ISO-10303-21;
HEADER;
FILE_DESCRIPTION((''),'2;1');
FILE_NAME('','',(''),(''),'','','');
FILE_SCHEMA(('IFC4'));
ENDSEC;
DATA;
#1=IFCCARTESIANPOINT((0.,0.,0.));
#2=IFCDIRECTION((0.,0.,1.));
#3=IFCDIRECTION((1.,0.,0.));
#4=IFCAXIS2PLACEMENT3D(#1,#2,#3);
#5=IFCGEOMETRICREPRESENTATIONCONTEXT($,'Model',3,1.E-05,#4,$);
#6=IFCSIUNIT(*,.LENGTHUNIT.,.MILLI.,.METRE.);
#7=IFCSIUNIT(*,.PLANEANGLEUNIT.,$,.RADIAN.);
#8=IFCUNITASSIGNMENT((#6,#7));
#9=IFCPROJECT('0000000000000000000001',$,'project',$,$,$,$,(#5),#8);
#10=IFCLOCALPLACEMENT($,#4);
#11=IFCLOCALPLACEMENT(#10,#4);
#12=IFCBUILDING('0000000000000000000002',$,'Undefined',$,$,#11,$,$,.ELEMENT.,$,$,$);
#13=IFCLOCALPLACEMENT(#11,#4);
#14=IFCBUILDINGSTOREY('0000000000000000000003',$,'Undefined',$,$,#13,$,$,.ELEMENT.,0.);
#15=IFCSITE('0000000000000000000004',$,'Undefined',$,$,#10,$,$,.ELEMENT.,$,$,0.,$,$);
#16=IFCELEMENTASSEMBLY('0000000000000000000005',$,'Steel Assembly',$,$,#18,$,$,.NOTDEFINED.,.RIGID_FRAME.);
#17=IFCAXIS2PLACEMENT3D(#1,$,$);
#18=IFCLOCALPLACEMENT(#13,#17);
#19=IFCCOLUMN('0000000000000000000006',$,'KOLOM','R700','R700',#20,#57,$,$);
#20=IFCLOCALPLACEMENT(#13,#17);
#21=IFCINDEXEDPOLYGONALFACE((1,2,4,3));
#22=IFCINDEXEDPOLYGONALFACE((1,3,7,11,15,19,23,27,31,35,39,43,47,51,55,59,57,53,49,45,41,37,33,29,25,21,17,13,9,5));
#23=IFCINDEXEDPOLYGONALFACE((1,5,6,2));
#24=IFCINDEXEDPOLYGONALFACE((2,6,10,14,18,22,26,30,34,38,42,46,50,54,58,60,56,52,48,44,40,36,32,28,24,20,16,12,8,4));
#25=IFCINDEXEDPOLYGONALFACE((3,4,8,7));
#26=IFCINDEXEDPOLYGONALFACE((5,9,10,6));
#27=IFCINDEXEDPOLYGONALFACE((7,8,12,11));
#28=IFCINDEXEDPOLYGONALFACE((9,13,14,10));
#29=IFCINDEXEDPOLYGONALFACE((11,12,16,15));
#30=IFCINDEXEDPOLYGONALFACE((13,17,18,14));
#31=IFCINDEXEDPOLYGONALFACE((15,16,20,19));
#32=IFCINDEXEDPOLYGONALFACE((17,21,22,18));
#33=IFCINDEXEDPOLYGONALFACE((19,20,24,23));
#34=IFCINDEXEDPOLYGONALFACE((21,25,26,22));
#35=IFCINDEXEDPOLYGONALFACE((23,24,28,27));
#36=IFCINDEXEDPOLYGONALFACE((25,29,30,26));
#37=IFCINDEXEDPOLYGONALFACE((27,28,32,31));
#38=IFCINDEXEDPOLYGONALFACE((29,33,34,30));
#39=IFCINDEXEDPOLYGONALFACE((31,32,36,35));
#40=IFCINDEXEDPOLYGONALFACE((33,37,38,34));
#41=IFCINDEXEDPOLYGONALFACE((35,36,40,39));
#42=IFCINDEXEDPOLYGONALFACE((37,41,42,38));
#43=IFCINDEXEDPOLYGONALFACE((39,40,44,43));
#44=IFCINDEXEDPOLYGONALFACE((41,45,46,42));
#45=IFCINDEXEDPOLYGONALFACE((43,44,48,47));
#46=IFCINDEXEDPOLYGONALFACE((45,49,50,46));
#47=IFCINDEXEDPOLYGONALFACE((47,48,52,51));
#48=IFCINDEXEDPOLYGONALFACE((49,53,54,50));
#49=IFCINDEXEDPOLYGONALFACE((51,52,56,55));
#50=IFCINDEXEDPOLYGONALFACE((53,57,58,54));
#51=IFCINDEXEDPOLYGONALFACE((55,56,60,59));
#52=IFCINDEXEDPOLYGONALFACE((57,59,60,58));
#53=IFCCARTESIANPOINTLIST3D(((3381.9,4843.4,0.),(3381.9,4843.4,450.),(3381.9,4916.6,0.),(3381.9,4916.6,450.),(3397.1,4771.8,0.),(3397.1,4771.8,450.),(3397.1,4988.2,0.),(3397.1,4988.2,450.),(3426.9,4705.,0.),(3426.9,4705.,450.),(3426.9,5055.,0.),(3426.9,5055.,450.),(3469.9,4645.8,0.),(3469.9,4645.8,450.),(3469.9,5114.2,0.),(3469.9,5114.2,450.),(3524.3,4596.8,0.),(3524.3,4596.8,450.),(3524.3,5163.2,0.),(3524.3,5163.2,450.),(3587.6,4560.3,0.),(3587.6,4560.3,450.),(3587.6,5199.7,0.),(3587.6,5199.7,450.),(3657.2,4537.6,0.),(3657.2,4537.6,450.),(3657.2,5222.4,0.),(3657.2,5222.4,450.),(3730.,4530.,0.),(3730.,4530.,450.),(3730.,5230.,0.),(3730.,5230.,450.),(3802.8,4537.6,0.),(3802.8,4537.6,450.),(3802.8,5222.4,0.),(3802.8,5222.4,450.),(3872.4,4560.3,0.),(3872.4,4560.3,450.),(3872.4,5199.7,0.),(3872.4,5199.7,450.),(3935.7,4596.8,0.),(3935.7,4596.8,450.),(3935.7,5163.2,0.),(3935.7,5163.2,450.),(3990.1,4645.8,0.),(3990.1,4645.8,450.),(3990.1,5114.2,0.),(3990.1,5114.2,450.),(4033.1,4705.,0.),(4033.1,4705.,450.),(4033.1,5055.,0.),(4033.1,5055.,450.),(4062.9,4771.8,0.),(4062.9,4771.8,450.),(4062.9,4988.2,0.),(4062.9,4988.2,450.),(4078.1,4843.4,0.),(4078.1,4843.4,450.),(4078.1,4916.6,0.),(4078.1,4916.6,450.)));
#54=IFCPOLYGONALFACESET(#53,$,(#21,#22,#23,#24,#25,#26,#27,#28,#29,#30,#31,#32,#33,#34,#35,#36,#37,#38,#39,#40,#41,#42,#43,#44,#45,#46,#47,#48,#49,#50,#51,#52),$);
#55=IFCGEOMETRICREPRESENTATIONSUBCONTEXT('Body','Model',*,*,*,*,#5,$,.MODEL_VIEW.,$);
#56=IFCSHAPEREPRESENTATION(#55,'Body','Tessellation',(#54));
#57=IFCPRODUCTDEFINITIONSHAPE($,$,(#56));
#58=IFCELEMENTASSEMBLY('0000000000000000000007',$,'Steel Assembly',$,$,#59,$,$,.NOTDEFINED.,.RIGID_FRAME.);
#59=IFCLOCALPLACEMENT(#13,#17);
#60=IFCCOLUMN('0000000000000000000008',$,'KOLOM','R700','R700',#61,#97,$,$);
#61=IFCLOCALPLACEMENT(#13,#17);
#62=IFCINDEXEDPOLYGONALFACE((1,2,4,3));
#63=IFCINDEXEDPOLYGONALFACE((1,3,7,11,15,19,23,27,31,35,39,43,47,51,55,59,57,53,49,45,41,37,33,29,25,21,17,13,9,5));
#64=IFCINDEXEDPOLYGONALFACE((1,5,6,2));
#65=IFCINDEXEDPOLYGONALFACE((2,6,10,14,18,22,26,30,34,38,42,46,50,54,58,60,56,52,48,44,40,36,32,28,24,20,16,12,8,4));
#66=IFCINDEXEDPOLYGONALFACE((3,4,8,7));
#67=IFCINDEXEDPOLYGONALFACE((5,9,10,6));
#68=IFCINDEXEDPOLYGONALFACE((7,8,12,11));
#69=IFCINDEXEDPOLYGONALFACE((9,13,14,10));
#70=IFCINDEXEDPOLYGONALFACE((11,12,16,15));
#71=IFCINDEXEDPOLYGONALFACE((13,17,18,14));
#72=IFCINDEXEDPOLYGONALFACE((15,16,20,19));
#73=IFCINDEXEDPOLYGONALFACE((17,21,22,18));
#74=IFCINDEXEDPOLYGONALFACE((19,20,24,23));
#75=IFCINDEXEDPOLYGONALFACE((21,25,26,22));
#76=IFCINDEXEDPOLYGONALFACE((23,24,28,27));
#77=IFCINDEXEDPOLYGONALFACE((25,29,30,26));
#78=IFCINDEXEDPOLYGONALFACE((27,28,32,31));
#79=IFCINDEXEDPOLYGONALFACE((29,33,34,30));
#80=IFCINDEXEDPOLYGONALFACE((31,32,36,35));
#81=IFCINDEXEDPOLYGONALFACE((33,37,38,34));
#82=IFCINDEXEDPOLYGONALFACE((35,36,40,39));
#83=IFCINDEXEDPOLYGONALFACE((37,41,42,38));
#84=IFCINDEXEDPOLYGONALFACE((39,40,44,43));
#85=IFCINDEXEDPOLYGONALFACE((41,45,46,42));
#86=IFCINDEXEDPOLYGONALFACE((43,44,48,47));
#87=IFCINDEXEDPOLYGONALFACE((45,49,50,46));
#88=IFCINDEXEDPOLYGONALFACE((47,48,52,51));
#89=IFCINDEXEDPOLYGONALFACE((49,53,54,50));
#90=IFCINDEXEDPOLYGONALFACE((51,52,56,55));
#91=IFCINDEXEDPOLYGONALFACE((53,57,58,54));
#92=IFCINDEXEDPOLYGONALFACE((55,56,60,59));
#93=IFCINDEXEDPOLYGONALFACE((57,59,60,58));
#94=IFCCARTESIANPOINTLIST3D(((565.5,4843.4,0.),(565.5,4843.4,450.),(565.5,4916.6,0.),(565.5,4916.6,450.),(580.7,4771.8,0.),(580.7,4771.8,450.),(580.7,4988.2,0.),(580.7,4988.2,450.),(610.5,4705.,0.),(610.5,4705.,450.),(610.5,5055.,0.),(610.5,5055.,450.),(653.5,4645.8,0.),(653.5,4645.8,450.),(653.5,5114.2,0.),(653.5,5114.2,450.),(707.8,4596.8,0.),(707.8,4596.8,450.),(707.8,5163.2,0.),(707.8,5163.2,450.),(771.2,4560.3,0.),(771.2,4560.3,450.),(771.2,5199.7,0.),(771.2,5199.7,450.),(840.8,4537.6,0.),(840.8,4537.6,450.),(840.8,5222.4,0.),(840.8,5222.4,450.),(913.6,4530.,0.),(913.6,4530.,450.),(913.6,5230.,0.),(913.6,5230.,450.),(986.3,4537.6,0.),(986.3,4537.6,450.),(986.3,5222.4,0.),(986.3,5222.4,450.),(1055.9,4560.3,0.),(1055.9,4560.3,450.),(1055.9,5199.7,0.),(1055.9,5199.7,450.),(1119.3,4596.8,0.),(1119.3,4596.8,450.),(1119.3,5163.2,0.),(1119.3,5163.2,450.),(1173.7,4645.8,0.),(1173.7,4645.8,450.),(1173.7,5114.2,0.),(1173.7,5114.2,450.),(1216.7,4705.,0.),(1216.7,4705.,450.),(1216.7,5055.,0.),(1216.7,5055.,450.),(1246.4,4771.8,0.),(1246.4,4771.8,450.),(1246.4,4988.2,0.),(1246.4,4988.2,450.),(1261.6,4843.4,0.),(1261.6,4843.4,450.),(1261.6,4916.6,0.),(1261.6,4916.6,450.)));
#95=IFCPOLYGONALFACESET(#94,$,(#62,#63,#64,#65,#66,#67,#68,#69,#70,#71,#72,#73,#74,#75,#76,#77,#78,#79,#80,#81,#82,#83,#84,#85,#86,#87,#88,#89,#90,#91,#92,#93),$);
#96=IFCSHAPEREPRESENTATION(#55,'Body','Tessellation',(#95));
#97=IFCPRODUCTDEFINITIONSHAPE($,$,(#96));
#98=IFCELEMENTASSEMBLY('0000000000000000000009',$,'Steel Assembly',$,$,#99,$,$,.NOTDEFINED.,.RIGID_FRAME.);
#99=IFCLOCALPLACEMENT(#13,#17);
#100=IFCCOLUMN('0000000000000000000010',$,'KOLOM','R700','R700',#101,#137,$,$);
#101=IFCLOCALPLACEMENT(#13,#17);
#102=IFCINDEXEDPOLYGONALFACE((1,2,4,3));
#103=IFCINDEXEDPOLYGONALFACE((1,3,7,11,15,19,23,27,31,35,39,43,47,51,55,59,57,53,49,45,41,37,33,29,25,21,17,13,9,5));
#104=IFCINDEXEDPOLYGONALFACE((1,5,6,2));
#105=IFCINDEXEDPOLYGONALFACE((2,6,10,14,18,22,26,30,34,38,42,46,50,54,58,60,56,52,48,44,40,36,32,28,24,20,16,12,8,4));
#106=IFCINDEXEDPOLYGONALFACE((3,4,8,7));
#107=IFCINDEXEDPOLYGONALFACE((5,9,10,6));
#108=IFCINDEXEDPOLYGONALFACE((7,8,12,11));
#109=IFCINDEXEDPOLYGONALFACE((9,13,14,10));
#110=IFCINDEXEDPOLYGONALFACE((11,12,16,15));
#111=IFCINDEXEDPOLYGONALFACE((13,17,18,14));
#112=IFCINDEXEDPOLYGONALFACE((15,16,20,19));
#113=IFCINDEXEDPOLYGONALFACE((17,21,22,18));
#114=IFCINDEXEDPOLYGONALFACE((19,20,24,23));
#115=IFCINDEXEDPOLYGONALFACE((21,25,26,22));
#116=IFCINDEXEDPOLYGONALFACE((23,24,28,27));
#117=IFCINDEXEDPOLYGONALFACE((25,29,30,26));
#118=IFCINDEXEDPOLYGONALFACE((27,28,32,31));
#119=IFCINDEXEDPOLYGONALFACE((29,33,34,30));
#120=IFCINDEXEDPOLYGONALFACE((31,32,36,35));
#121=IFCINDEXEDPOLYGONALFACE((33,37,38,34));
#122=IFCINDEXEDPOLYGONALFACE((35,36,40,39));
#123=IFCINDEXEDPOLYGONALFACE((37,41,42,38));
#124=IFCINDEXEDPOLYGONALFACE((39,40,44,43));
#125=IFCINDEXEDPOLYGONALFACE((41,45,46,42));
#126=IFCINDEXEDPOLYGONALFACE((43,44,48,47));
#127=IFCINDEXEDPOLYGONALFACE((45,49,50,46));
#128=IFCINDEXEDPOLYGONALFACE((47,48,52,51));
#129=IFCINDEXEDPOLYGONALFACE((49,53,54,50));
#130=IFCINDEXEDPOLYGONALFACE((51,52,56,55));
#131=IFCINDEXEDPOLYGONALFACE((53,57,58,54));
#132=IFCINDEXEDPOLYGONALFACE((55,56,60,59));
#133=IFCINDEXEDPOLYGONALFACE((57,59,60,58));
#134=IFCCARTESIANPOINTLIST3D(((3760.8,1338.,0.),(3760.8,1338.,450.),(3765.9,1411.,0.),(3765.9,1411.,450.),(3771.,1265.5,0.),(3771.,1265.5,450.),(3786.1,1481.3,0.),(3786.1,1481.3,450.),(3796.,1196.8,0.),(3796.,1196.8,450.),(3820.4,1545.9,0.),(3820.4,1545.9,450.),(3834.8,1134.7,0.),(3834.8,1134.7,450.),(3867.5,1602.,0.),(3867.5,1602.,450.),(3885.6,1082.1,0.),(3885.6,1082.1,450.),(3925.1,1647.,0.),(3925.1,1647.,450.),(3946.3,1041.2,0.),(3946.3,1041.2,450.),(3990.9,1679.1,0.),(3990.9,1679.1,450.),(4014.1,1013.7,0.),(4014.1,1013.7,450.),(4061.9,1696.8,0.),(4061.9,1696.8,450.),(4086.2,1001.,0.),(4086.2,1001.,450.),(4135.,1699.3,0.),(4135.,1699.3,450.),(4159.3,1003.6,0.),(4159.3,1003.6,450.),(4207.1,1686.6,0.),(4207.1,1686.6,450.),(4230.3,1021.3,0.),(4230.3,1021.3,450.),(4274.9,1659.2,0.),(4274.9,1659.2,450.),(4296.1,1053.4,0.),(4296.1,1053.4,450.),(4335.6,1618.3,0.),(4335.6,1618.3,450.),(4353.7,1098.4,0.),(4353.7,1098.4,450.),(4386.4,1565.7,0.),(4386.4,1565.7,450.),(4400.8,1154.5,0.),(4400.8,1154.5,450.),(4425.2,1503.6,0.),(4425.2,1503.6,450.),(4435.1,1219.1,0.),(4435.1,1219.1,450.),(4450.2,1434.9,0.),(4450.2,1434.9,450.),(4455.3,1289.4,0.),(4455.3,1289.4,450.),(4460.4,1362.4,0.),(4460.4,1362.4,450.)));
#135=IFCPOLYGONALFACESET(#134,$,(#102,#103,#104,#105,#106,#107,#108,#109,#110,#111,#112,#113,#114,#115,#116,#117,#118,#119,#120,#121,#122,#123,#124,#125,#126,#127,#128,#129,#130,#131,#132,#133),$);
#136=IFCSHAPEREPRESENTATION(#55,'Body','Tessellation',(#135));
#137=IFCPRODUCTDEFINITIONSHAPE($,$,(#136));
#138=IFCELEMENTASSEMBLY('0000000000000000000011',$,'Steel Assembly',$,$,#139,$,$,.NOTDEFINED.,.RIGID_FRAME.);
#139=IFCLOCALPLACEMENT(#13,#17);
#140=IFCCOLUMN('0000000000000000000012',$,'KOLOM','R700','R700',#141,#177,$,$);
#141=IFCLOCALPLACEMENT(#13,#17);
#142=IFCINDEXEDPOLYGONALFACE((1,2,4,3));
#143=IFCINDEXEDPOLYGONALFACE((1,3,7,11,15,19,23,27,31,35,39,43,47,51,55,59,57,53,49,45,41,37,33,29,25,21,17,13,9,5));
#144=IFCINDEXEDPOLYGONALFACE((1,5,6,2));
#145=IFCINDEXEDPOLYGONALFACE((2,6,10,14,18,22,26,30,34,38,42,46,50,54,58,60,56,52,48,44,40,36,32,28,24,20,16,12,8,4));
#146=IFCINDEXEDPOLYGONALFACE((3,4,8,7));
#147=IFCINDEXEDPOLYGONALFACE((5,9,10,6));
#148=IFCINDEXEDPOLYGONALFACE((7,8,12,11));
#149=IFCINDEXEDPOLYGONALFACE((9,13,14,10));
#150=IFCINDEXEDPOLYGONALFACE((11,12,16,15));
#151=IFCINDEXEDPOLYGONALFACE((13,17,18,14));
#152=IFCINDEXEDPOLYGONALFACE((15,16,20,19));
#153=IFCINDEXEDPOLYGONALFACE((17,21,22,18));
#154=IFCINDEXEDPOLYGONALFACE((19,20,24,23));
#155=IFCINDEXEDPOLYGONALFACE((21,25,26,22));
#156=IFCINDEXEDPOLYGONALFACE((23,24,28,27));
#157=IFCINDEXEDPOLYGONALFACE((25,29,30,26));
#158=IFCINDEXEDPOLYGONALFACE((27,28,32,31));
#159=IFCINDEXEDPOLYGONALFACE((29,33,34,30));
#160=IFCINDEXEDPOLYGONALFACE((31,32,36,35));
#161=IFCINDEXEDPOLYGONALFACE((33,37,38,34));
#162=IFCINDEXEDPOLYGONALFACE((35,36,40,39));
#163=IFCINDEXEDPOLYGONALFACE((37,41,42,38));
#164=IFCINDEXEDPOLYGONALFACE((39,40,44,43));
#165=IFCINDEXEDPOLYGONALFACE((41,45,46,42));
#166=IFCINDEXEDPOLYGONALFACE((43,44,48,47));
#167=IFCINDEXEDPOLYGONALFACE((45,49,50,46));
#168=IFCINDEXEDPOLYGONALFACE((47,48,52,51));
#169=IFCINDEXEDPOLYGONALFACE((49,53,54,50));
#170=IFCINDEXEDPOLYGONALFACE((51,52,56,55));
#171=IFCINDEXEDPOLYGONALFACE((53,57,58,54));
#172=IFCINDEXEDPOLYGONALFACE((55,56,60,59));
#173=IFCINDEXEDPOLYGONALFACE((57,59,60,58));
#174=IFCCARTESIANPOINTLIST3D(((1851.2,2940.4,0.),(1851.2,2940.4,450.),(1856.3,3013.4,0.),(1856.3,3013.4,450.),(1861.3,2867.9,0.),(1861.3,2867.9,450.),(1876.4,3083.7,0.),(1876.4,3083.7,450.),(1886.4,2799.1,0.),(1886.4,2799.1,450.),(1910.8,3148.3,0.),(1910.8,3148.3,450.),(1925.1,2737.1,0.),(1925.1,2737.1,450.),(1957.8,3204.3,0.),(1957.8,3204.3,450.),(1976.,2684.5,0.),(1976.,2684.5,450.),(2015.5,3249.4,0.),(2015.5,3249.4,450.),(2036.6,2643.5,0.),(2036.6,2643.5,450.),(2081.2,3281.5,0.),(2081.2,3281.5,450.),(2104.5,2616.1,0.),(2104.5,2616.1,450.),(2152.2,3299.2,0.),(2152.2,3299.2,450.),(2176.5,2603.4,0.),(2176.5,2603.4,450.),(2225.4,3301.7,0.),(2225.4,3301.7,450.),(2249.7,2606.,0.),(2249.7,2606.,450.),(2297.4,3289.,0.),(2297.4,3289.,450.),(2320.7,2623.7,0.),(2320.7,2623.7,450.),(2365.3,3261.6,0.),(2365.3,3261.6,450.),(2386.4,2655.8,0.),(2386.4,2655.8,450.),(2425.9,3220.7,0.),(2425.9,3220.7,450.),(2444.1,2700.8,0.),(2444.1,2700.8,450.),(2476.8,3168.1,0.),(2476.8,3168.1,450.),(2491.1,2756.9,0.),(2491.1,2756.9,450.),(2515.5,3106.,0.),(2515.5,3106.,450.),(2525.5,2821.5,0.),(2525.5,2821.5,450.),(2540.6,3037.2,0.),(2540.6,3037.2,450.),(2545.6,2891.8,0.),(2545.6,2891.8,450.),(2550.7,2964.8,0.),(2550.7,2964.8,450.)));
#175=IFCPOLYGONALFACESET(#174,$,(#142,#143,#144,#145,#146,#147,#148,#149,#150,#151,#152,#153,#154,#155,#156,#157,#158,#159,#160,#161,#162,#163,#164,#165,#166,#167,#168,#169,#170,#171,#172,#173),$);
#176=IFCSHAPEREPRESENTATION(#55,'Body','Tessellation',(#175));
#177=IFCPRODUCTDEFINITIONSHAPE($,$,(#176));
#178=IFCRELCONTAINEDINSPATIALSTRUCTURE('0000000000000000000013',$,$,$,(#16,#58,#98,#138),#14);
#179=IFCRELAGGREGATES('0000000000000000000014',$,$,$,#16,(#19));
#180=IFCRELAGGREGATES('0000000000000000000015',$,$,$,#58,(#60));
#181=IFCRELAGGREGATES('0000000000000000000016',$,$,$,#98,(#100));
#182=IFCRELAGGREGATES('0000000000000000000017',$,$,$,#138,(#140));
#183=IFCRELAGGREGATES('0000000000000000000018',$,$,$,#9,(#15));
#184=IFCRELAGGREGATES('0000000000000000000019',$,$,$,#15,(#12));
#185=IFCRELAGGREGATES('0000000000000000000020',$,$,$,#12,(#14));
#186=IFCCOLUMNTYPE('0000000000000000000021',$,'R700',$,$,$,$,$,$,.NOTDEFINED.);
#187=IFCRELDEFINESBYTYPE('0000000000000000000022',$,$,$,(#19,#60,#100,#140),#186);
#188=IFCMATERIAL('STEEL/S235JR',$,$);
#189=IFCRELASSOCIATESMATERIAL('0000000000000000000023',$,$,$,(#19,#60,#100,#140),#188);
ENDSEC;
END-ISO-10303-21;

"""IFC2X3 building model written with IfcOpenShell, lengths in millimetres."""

from ifc_helpers import new_model, si_unit, frame, origin_with_axes, origin_2d_with_axis, place, context, subcontext, project, spatial, circle, extrude, material, type_object, element, aggregate, save


model = new_model("IFC2X3")

# Units and contexts
model_context = context("Model", 3, precision=1e-05, world=origin_with_axes())
body_context = subcontext(model_context, "Body", "Model", "MODEL_VIEW")
ifc_project = project(units=[si_unit("LENGTHUNIT", "METRE", prefix="MILLI"), si_unit("PLANEANGLEUNIT", "RADIAN")], contexts=[model_context])

# Site, building, storey
site_placement = place(None, origin_with_axes())
site = spatial("IfcSite", under=ifc_project, at=site_placement, Name="Undefined", CompositionType="ELEMENT", RefElevation=0.0)
building_placement = place(site_placement, origin_with_axes())
building = spatial("IfcBuilding", under=site, at=building_placement, Name="Undefined", CompositionType="ELEMENT")
storey_placement = place(building_placement, origin_with_axes())
storey = spatial("IfcBuildingStorey", under=building, at=storey_placement, Name="Undefined", CompositionType="ELEMENT", Elevation=0.0)

# Element assemblies, columns
ifc_material = material(Name="STEEL/S235JR")
column_type = type_object("IfcColumnType", Name="R700", PredefinedType="NOTDEFINED")
assembly_1_placement = place(storey_placement, origin_with_axes())
assembly_1 = element("IfcElementAssembly", 1, at=assembly_1_placement, inside=storey, Name="Steel Assembly", AssemblyPlace="NOTDEFINED", PredefinedType="RIGID_FRAME")
column_1_placement = place(assembly_1_placement, frame((3730.0, 4880.0, 0.0), z_axis=(0.0, 0.0, 1.0), x_axis=(-1.0, 0.0, 0.0)))
column_1 = element("IfcColumn", 2, at=column_1_placement, type_object=column_type, material=ifc_material, Name="KOLOM", Description="R700", ObjectType="R700", context=body_context, shape_type="SweptSolid", body=[
    extrude(circle(Radius=350.0, at=origin_2d_with_axis()), frame((0.0, 0.0, 450.0), z_axis=(0.0, 0.0, -1.0), x_axis=(0.0, 1.0, 0.0)), (0.0, 0.0, 1.0), 450.0),
])
aggregate(assembly_1, [column_1])
assembly_2_placement = place(storey_placement, origin_with_axes())
assembly_2 = element("IfcElementAssembly", 3, at=assembly_2_placement, inside=storey, Name="Steel Assembly", AssemblyPlace="NOTDEFINED", PredefinedType="RIGID_FRAME")
column_2_placement = place(assembly_2_placement, frame((913.6, 4880.0, 0.0), z_axis=(0.0, 0.0, 1.0), x_axis=(-1.0, 0.0, 0.0)))
column_2 = element("IfcColumn", 4, at=column_2_placement, type_object=column_type, material=ifc_material, Name="KOLOM", Description="R700", ObjectType="R700", context=body_context, shape_type="SweptSolid", body=[
    extrude(circle(Radius=350.0, at=origin_2d_with_axis()), frame((0.0, 0.0, 450.0), z_axis=(0.0, 0.0, -1.0), x_axis=(0.0, 1.0, 0.0)), (0.0, 0.0, 1.0), 450.0),
])
aggregate(assembly_2, [column_2])
assembly_3_placement = place(storey_placement, origin_with_axes())
assembly_3 = element("IfcElementAssembly", 5, at=assembly_3_placement, inside=storey, Name="Steel Assembly", AssemblyPlace="NOTDEFINED", PredefinedType="RIGID_FRAME")
column_3_placement = place(assembly_3_placement, frame((4110.6, 1350.2, 450.0), z_axis=(0.0, 0.0, -1.0), x_axis=(0.766044, -0.642788, 0.0)))
column_3 = element("IfcColumn", 6, at=column_3_placement, type_object=column_type, material=ifc_material, Name="KOLOM", Description="R700", ObjectType="R700", context=body_context, shape_type="SweptSolid", body=[
    extrude(circle(Radius=350.0, at=origin_2d_with_axis()), frame((0.0, 0.0, 450.0), z_axis=(0.0, 0.0, -1.0), x_axis=(0.0, 1.0, 0.0)), (0.0, 0.0, 1.0), 450.0),
])
aggregate(assembly_3, [column_3])
assembly_4_placement = place(storey_placement, origin_with_axes())
assembly_4 = element("IfcElementAssembly", 7, at=assembly_4_placement, inside=storey, Name="Steel Assembly", AssemblyPlace="NOTDEFINED", PredefinedType="RIGID_FRAME")
column_4_placement = place(assembly_4_placement, frame((2201.0, 2952.6, 450.0), z_axis=(0.0, 0.0, -1.0), x_axis=(-0.766044, 0.642788, 0.0)))
column_4 = element("IfcColumn", 8, at=column_4_placement, type_object=column_type, material=ifc_material, Name="KOLOM", Description="R700", ObjectType="R700", context=body_context, shape_type="SweptSolid", body=[
    extrude(circle(Radius=350.0, at=origin_2d_with_axis()), frame((0.0, 0.0, 450.0), z_axis=(0.0, 0.0, -1.0), x_axis=(0.0, 1.0, 0.0)), (0.0, 0.0, 1.0), 450.0),
])
aggregate(assembly_4, [column_4])

save(model, "model.ifc")
